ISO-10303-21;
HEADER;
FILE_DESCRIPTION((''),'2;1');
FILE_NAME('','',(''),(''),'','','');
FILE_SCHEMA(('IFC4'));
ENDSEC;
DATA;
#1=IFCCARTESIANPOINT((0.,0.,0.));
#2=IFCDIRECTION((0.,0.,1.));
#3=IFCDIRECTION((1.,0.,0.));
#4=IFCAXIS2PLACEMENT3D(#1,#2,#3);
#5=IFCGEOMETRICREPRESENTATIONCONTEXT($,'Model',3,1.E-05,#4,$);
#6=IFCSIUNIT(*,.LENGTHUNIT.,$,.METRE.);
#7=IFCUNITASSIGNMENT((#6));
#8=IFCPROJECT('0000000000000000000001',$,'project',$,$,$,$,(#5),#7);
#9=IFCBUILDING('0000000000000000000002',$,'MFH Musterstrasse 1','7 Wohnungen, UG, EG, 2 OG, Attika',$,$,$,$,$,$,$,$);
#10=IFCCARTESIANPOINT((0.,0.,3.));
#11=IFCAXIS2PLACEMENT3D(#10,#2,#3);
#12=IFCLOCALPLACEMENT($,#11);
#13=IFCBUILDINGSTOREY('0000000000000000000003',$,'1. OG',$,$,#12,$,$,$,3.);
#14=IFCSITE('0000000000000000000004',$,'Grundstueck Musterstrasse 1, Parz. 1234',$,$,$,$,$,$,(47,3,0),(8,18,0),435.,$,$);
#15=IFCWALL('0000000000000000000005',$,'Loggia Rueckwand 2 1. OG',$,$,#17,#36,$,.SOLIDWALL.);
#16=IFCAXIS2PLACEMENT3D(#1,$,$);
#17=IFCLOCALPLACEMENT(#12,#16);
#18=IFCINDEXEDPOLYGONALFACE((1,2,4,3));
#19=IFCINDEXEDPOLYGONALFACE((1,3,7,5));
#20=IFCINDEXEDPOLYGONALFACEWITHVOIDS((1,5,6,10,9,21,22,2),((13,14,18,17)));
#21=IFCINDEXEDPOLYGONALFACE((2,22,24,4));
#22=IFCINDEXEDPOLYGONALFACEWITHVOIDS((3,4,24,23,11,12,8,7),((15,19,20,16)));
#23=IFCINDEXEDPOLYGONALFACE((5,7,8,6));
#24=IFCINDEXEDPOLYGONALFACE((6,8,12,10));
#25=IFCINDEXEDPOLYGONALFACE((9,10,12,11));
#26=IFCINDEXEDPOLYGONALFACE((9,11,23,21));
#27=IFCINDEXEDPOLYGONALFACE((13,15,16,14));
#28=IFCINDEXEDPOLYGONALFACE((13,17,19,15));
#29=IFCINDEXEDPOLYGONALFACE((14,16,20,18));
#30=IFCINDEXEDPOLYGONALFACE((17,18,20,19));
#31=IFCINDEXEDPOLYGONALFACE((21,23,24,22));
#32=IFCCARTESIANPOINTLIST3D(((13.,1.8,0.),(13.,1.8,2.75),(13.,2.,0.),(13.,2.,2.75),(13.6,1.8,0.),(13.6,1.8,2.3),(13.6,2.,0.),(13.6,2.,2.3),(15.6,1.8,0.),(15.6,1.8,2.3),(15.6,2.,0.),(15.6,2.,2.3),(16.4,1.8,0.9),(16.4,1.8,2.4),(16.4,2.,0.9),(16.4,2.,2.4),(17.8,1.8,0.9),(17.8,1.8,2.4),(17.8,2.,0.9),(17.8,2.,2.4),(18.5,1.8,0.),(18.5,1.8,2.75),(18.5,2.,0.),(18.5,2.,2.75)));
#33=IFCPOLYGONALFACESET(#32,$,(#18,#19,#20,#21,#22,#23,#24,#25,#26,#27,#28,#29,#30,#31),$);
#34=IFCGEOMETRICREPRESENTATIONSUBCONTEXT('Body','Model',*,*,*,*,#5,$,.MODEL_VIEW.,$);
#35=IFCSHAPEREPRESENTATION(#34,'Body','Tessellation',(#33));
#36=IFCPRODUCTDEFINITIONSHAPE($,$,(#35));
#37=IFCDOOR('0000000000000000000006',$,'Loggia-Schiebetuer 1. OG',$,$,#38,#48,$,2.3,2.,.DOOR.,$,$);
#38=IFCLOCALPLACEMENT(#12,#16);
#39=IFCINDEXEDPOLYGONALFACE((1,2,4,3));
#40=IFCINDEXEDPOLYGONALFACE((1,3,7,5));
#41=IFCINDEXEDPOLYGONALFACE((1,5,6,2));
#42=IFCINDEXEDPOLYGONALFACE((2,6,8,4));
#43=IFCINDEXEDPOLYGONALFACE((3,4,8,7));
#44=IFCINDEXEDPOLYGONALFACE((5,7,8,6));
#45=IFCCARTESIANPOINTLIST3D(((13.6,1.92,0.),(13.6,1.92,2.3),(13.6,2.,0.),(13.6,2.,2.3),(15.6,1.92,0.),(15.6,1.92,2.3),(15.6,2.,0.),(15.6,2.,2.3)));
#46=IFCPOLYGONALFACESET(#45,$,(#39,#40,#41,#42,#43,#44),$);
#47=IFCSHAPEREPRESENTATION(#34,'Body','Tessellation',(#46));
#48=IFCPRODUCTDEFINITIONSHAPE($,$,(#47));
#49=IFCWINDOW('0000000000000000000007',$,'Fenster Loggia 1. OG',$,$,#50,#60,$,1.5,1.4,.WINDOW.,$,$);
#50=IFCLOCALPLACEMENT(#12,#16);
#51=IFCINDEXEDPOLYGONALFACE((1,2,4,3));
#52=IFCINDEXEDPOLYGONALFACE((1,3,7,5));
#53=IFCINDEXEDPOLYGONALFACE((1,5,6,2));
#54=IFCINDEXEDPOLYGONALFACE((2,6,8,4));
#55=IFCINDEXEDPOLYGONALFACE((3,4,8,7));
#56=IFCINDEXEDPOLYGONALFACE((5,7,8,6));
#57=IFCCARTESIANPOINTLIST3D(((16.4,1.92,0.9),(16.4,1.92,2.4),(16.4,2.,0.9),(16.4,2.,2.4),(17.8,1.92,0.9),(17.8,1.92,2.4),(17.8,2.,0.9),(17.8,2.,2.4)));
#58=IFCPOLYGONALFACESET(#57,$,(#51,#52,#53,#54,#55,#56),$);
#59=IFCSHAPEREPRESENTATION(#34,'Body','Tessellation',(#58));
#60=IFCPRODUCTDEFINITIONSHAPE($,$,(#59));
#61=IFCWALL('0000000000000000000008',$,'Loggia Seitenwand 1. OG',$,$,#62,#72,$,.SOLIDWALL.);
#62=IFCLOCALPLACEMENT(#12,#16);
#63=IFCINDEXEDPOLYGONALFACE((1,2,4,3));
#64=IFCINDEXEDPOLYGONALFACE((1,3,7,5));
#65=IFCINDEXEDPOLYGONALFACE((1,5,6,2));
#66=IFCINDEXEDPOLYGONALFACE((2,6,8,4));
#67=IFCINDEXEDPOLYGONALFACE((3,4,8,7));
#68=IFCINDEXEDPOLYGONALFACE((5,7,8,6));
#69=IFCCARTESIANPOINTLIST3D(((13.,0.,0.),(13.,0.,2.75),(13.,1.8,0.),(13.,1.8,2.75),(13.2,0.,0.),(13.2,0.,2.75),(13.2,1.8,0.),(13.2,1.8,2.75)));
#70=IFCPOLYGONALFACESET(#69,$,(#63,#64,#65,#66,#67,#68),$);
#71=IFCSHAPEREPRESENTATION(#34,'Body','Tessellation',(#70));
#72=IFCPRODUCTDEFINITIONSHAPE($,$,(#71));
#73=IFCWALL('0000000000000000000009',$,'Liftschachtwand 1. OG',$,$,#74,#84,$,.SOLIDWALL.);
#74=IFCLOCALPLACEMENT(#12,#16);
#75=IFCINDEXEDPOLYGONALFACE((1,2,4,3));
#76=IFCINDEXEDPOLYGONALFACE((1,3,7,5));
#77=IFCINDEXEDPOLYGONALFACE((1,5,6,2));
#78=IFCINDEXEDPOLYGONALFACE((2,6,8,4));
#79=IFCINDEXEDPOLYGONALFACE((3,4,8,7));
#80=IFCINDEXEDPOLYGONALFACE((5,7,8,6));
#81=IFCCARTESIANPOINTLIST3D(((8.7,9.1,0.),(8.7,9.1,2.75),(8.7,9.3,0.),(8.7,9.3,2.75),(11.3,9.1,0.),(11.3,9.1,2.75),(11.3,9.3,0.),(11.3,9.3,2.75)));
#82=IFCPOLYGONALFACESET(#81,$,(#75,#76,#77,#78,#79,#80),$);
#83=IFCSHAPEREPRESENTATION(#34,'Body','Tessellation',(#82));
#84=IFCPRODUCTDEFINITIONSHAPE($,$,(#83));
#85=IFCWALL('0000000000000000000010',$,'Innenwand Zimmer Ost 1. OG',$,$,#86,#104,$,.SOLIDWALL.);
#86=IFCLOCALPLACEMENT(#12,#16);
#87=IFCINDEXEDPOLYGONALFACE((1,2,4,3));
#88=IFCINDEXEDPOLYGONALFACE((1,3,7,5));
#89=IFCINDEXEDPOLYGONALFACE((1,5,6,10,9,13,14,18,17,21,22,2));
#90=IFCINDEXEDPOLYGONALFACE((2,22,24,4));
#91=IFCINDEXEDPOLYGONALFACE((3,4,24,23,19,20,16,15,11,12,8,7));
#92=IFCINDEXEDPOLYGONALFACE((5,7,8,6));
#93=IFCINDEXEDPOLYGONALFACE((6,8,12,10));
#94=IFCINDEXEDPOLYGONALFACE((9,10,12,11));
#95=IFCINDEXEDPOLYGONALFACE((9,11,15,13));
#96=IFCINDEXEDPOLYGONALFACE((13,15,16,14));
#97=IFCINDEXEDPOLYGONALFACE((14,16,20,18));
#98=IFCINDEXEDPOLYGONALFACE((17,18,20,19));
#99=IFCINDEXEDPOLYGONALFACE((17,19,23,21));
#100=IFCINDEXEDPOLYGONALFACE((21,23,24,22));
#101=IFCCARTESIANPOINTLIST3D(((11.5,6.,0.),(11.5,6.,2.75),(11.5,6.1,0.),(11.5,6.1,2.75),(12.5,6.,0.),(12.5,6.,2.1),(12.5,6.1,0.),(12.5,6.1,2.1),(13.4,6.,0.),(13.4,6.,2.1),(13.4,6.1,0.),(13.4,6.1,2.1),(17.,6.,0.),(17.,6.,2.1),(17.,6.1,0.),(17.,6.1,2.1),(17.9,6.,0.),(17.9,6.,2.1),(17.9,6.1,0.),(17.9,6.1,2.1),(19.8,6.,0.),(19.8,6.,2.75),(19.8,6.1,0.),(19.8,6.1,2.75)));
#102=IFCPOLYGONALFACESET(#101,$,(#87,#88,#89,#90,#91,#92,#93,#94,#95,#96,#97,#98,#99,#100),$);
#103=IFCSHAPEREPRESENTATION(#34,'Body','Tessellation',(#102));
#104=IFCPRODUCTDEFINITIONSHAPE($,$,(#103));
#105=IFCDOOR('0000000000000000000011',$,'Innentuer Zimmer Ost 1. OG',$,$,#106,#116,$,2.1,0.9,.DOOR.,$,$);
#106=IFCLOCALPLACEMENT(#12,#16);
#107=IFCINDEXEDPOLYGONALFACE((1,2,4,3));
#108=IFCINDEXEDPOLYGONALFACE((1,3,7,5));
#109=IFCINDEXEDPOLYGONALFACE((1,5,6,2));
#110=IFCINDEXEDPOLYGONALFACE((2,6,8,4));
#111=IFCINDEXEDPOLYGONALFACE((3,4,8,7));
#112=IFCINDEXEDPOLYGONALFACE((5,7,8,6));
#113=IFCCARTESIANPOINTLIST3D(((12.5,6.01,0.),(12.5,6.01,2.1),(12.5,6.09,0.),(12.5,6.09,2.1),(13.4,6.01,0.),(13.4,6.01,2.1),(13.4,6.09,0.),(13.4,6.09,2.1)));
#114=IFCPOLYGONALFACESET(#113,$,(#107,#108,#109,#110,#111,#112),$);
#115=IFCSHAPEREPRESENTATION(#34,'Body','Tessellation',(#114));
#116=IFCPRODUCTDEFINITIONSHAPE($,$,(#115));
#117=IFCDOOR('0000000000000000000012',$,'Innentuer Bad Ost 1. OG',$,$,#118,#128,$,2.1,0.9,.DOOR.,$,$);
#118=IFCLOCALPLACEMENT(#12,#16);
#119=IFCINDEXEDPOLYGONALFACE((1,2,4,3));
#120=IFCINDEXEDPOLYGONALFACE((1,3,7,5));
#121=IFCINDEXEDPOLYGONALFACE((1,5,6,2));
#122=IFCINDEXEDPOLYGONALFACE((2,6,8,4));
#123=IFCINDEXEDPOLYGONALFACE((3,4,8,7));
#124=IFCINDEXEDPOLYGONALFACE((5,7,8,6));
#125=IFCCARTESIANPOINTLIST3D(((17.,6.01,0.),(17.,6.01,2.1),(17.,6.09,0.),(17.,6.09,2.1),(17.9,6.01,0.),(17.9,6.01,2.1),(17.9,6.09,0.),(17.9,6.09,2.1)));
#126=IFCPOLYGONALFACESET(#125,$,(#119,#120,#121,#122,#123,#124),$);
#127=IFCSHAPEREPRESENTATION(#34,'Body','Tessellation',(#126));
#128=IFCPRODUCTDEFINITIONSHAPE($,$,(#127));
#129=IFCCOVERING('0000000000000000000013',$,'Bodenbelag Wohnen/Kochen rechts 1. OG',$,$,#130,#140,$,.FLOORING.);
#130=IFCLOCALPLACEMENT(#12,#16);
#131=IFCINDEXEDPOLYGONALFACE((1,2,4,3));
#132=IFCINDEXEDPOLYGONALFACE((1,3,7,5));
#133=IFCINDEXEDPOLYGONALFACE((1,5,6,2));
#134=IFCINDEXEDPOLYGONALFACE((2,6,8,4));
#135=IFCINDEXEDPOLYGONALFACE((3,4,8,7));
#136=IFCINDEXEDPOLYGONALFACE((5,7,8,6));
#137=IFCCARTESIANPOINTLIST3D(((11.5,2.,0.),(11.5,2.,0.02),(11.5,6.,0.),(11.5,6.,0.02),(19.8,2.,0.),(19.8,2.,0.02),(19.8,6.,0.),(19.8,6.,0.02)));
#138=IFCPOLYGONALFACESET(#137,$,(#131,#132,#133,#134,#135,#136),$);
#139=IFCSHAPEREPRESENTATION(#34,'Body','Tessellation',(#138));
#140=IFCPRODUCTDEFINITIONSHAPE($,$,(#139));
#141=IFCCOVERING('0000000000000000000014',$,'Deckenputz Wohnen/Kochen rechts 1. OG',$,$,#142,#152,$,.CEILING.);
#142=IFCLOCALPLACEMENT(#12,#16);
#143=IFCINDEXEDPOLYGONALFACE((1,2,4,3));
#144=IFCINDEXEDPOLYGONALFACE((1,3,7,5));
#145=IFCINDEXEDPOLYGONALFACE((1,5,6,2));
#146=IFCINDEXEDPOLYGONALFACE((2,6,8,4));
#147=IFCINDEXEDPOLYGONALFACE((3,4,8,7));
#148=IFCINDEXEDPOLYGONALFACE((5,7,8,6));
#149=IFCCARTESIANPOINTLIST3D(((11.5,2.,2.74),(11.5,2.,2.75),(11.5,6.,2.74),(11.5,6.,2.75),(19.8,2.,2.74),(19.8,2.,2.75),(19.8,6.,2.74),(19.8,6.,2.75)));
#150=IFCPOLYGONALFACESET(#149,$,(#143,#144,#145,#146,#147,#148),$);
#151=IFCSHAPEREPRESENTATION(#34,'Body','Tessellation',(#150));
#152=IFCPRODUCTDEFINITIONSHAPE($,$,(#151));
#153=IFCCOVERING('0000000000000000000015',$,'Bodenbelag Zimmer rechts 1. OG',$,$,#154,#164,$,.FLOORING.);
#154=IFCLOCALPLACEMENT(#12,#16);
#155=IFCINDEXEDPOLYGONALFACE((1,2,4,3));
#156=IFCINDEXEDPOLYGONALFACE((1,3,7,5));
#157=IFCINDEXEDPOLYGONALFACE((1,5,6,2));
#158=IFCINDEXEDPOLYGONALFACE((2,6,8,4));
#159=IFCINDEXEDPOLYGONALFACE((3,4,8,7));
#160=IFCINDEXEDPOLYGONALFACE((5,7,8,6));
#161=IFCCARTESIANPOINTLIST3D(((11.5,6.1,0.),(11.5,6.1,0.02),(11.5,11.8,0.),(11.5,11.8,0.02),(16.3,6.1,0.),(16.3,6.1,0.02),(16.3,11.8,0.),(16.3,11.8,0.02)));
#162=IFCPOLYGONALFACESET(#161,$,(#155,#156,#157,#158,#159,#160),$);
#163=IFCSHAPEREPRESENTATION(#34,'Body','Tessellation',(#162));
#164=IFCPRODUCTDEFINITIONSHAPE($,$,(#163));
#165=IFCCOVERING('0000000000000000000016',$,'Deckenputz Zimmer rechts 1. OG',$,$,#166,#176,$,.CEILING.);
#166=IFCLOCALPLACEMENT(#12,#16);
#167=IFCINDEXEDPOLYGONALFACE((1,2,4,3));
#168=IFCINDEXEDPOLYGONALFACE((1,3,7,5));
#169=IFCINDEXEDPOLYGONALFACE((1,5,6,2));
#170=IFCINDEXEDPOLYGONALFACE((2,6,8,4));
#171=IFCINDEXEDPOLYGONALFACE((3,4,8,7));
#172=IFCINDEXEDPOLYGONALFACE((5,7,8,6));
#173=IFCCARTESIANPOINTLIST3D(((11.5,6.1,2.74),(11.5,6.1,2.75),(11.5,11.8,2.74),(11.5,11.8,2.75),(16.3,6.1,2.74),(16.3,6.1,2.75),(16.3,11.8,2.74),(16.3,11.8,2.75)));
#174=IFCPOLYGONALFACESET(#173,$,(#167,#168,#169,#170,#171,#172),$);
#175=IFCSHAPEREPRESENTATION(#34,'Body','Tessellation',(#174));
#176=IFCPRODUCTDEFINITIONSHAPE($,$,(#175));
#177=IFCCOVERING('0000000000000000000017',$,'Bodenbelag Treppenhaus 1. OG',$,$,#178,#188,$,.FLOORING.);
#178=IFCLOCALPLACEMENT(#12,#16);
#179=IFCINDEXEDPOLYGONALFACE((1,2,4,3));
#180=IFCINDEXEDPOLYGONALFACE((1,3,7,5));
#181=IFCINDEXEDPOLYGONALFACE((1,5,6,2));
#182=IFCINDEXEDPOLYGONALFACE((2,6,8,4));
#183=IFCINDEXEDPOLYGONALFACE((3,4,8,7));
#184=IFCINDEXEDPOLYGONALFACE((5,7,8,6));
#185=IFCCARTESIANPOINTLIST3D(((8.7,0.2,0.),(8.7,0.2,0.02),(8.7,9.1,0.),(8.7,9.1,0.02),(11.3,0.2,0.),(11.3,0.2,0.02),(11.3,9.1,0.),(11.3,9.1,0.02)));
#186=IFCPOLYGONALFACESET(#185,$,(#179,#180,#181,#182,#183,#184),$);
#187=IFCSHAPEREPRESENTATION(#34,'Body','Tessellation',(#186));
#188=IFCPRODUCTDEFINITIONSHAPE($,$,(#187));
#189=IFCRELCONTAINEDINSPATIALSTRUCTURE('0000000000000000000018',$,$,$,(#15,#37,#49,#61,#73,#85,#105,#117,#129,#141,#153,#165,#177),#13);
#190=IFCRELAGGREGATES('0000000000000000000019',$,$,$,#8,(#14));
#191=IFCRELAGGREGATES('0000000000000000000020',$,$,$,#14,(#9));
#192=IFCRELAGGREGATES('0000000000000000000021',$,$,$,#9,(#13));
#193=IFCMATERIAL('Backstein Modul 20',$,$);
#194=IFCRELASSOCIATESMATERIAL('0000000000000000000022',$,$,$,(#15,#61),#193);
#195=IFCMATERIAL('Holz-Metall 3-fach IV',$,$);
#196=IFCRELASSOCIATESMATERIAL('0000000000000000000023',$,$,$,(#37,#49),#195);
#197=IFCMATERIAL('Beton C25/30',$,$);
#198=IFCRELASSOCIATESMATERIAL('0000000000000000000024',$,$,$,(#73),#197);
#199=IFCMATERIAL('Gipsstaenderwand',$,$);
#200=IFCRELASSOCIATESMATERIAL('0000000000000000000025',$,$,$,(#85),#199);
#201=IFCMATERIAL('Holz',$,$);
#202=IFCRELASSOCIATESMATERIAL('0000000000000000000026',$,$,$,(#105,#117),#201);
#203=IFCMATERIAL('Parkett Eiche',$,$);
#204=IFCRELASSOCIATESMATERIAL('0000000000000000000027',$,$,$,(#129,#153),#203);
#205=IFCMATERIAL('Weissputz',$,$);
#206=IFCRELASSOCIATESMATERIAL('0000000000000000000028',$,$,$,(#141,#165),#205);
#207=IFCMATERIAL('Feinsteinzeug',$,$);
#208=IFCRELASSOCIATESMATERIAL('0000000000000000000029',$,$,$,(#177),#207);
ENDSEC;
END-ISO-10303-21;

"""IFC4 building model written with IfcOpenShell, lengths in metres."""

from ifc_helpers import new_model, si_unit, frame, frame_2d, origin_with_axes, place, context, subcontext, project, spatial, rectangle, extrude, material, element, fill, save


model = new_model("IFC4")

# Units and contexts
model_context = context("Model", 3, precision=1e-05, world=origin_with_axes())
body_context = subcontext(model_context, "Body", "Model", "MODEL_VIEW")
ifc_project = project(units=[si_unit("LENGTHUNIT", "METRE")], contexts=[model_context])

# Site, building, storey
site = spatial("IfcSite", under=ifc_project, Name="Grundstueck Musterstrasse 1, Parz. 1234", RefLatitude=(47, 3, 0), RefLongitude=(8, 18, 0), RefElevation=435.0)
building = spatial("IfcBuilding", under=site, Name="MFH Musterstrasse 1", Description="7 Wohnungen, UG, EG, 2 OG, Attika")
storey_placement = place(None, frame((0.0, 0.0, 3.0), z_axis=(0.0, 0.0, 1.0), x_axis=(1.0, 0.0, 0.0)))
storey = spatial("IfcBuildingStorey", under=building, at=storey_placement, Name="1. OG", Elevation=3.0)

# Wall, openings, door, window
ifc_material_1 = material(Name="Backstein Modul 20")
wall_1_placement = place(storey_placement, frame((13.0, 1.8, 0.0), z_axis=(0.0, 0.0, 1.0), x_axis=(1.0, 0.0, 0.0)))
wall_1 = element("IfcWall", 1, at=wall_1_placement, inside=storey, material=ifc_material_1, Name="Loggia Rueckwand 2 1. OG", PredefinedType="SOLIDWALL", context=body_context, shape_type="SweptSolid", body=[
    extrude(rectangle(XDim=5.5, YDim=0.2, at=frame_2d((2.75, 0.1))), origin_with_axes(), (0.0, 0.0, 1.0), 2.75),
])
opening_1_placement = place(wall_1_placement, frame((0.6, -0.21, 0.0), z_axis=(0.0, 0.0, 1.0), x_axis=(1.0, 0.0, 0.0)))
opening_1 = element("IfcOpeningElement", 2, at=opening_1_placement, cuts=wall_1, context=body_context, shape_type="SweptSolid", body=[
    extrude(rectangle(XDim=2.0, YDim=0.42, at=frame_2d((1.0, 0.21))), origin_with_axes(), (0.0, 0.0, 1.0), 2.3),
])
opening_2_placement = place(wall_1_placement, frame((3.4, -0.21, 0.9), z_axis=(0.0, 0.0, 1.0), x_axis=(1.0, 0.0, 0.0)))
opening_2 = element("IfcOpeningElement", 3, at=opening_2_placement, cuts=wall_1, context=body_context, shape_type="SweptSolid", body=[
    extrude(rectangle(XDim=1.4, YDim=0.42, at=frame_2d((0.7, 0.21))), origin_with_axes(), (0.0, 0.0, 1.0), 1.5),
])
ifc_material_2 = material(Name="Holz-Metall 3-fach IV")
door_1_placement = place(storey_placement, frame((13.6, 1.92, 0.0), z_axis=(0.0, 0.0, 1.0), x_axis=(1.0, 0.0, 0.0)))
door_1 = element("IfcDoor", 4, at=door_1_placement, inside=storey, material=ifc_material_2, Name="Loggia-Schiebetuer 1. OG", OverallHeight=2.3, OverallWidth=2.0, PredefinedType="DOOR", context=body_context, shape_type="SweptSolid", body=[
    extrude(rectangle(XDim=2.0, YDim=0.08, at=frame_2d((1.0, 0.04))), origin_with_axes(), (0.0, 0.0, 1.0), 2.3),
])
fill(opening_1, door_1)
window_placement = place(storey_placement, frame((16.4, 1.92, 0.9), z_axis=(0.0, 0.0, 1.0), x_axis=(1.0, 0.0, 0.0)))
window = element("IfcWindow", 5, at=window_placement, inside=storey, material=ifc_material_2, Name="Fenster Loggia 1. OG", OverallHeight=1.5, OverallWidth=1.4, PredefinedType="WINDOW", context=body_context, shape_type="SweptSolid", body=[
    extrude(rectangle(XDim=1.4, YDim=0.08, at=frame_2d((0.7, 0.04))), origin_with_axes(), (0.0, 0.0, 1.0), 1.5),
])
fill(opening_2, window)

# Wall
wall_2_placement = place(storey_placement, frame((13.0, 0.2, 0.0), z_axis=(0.0, 0.0, 1.0), x_axis=(1.0, 0.0, 0.0)))
element("IfcWall", 6, at=wall_2_placement, inside=storey, material=ifc_material_1, Name="Loggia Seitenwand 1. OG", PredefinedType="SOLIDWALL", context=body_context, shape_type="SweptSolid", body=[
    extrude(rectangle(XDim=0.2, YDim=1.8, at=frame_2d((0.1, 0.7))), origin_with_axes(), (0.0, 0.0, 1.0), 2.75),
])

# Shared definitions
ifc_material_3 = material(Name="Beton C25/30")
ifc_material_4 = material(Name="Holz")

# Wall
wall_3_placement = place(storey_placement, frame((8.7, 9.1, 0.0), z_axis=(0.0, 0.0, 1.0), x_axis=(1.0, 0.0, 0.0)))
element("IfcWall", 7, at=wall_3_placement, inside=storey, material=ifc_material_3, Name="Liftschachtwand 1. OG", PredefinedType="SOLIDWALL", context=body_context, shape_type="SweptSolid", body=[
    extrude(rectangle(XDim=2.6, YDim=0.2, at=frame_2d((1.3, 0.1))), origin_with_axes(), (0.0, 0.0, 1.0), 2.75),
])

# Wall, openings, doors
ifc_material_5 = material(Name="Gipsstaenderwand")
wall_4_placement = place(storey_placement, frame((11.5, 6.0, 0.0), z_axis=(0.0, 0.0, 1.0), x_axis=(1.0, 0.0, 0.0)))
wall_4 = element("IfcWall", 8, at=wall_4_placement, inside=storey, material=ifc_material_5, Name="Innenwand Zimmer Ost 1. OG", PredefinedType="SOLIDWALL", context=body_context, shape_type="SweptSolid", body=[
    extrude(rectangle(XDim=8.3, YDim=0.1, at=frame_2d((4.15, 0.05))), origin_with_axes(), (0.0, 0.0, 1.0), 2.75),
])
opening_3_placement = place(wall_4_placement, frame((1.0, -0.01, 0.0), z_axis=(0.0, 0.0, 1.0), x_axis=(1.0, 0.0, 0.0)))
opening_3 = element("IfcOpeningElement", 9, at=opening_3_placement, cuts=wall_4, context=body_context, shape_type="SweptSolid", body=[
    extrude(rectangle(XDim=0.9, YDim=0.12, at=frame_2d((0.45, 0.06))), origin_with_axes(), (0.0, 0.0, 1.0), 2.1),
])
opening_4_placement = place(wall_4_placement, frame((5.5, -0.01, 0.0), z_axis=(0.0, 0.0, 1.0), x_axis=(1.0, 0.0, 0.0)))
opening_4 = element("IfcOpeningElement", 10, at=opening_4_placement, cuts=wall_4, context=body_context, shape_type="SweptSolid", body=[
    extrude(rectangle(XDim=0.9, YDim=0.12, at=frame_2d((0.45, 0.06))), origin_with_axes(), (0.0, 0.0, 1.0), 2.1),
])
door_2_placement = place(storey_placement, frame((12.5, 6.01, 0.0), z_axis=(0.0, 0.0, 1.0), x_axis=(1.0, 0.0, 0.0)))
door_2 = element("IfcDoor", 11, at=door_2_placement, inside=storey, material=ifc_material_4, Name="Innentuer Zimmer Ost 1. OG", OverallHeight=2.1, OverallWidth=0.9, PredefinedType="DOOR", context=body_context, shape_type="SweptSolid", body=[
    extrude(rectangle(XDim=0.9, YDim=0.08, at=frame_2d((0.45, 0.04))), origin_with_axes(), (0.0, 0.0, 1.0), 2.1),
])
fill(opening_3, door_2)
door_3_placement = place(storey_placement, frame((17.0, 6.01, 0.0), z_axis=(0.0, 0.0, 1.0), x_axis=(1.0, 0.0, 0.0)))
door_3 = element("IfcDoor", 12, at=door_3_placement, inside=storey, material=ifc_material_4, Name="Innentuer Bad Ost 1. OG", OverallHeight=2.1, OverallWidth=0.9, PredefinedType="DOOR", context=body_context, shape_type="SweptSolid", body=[
    extrude(rectangle(XDim=0.9, YDim=0.08, at=frame_2d((0.45, 0.04))), origin_with_axes(), (0.0, 0.0, 1.0), 2.1),
])
fill(opening_4, door_3)

# Coverings
ifc_material_6 = material(Name="Parkett Eiche")
covering_1_placement = place(storey_placement, frame((11.5, 2.0, 0.0), z_axis=(0.0, 0.0, 1.0), x_axis=(1.0, 0.0, 0.0)))
element("IfcCovering", 13, at=covering_1_placement, inside=storey, material=ifc_material_6, Name="Bodenbelag Wohnen/Kochen rechts 1. OG", PredefinedType="FLOORING", context=body_context, shape_type="SweptSolid", body=[
    extrude(rectangle(XDim=8.3, YDim=4.0, at=frame_2d((4.15, 2.0))), origin_with_axes(), (0.0, 0.0, 1.0), 0.02),
])
ifc_material_7 = material(Name="Weissputz")
covering_2_placement = place(storey_placement, frame((11.5, 2.0, 2.74), z_axis=(0.0, 0.0, 1.0), x_axis=(1.0, 0.0, 0.0)))
element("IfcCovering", 14, at=covering_2_placement, inside=storey, material=ifc_material_7, Name="Deckenputz Wohnen/Kochen rechts 1. OG", PredefinedType="CEILING", context=body_context, shape_type="SweptSolid", body=[
    extrude(rectangle(XDim=8.3, YDim=4.0, at=frame_2d((4.15, 2.0))), origin_with_axes(), (0.0, 0.0, 1.0), 0.01),
])
covering_3_placement = place(storey_placement, frame((11.5, 6.1, 0.0), z_axis=(0.0, 0.0, 1.0), x_axis=(1.0, 0.0, 0.0)))
element("IfcCovering", 15, at=covering_3_placement, inside=storey, material=ifc_material_6, Name="Bodenbelag Zimmer rechts 1. OG", PredefinedType="FLOORING", context=body_context, shape_type="SweptSolid", body=[
    extrude(rectangle(XDim=4.8, YDim=5.7, at=frame_2d((2.4, 2.85))), origin_with_axes(), (0.0, 0.0, 1.0), 0.02),
])
covering_4_placement = place(storey_placement, frame((11.5, 6.1, 2.74), z_axis=(0.0, 0.0, 1.0), x_axis=(1.0, 0.0, 0.0)))
element("IfcCovering", 16, at=covering_4_placement, inside=storey, material=ifc_material_7, Name="Deckenputz Zimmer rechts 1. OG", PredefinedType="CEILING", context=body_context, shape_type="SweptSolid", body=[
    extrude(rectangle(XDim=4.8, YDim=5.7, at=frame_2d((2.4, 2.85))), origin_with_axes(), (0.0, 0.0, 1.0), 0.01),
])
ifc_material_8 = material(Name="Feinsteinzeug")
covering_5_placement = place(storey_placement, frame((8.7, 0.2, 0.0), z_axis=(0.0, 0.0, 1.0), x_axis=(1.0, 0.0, 0.0)))
element("IfcCovering", 17, at=covering_5_placement, inside=storey, material=ifc_material_8, Name="Bodenbelag Treppenhaus 1. OG", PredefinedType="FLOORING", context=body_context, shape_type="SweptSolid", body=[
    extrude(rectangle(XDim=2.6, YDim=8.9, at=frame_2d((1.3, 4.45))), origin_with_axes(), (0.0, 0.0, 1.0), 0.02),
])

save(model, "model.ifc")
